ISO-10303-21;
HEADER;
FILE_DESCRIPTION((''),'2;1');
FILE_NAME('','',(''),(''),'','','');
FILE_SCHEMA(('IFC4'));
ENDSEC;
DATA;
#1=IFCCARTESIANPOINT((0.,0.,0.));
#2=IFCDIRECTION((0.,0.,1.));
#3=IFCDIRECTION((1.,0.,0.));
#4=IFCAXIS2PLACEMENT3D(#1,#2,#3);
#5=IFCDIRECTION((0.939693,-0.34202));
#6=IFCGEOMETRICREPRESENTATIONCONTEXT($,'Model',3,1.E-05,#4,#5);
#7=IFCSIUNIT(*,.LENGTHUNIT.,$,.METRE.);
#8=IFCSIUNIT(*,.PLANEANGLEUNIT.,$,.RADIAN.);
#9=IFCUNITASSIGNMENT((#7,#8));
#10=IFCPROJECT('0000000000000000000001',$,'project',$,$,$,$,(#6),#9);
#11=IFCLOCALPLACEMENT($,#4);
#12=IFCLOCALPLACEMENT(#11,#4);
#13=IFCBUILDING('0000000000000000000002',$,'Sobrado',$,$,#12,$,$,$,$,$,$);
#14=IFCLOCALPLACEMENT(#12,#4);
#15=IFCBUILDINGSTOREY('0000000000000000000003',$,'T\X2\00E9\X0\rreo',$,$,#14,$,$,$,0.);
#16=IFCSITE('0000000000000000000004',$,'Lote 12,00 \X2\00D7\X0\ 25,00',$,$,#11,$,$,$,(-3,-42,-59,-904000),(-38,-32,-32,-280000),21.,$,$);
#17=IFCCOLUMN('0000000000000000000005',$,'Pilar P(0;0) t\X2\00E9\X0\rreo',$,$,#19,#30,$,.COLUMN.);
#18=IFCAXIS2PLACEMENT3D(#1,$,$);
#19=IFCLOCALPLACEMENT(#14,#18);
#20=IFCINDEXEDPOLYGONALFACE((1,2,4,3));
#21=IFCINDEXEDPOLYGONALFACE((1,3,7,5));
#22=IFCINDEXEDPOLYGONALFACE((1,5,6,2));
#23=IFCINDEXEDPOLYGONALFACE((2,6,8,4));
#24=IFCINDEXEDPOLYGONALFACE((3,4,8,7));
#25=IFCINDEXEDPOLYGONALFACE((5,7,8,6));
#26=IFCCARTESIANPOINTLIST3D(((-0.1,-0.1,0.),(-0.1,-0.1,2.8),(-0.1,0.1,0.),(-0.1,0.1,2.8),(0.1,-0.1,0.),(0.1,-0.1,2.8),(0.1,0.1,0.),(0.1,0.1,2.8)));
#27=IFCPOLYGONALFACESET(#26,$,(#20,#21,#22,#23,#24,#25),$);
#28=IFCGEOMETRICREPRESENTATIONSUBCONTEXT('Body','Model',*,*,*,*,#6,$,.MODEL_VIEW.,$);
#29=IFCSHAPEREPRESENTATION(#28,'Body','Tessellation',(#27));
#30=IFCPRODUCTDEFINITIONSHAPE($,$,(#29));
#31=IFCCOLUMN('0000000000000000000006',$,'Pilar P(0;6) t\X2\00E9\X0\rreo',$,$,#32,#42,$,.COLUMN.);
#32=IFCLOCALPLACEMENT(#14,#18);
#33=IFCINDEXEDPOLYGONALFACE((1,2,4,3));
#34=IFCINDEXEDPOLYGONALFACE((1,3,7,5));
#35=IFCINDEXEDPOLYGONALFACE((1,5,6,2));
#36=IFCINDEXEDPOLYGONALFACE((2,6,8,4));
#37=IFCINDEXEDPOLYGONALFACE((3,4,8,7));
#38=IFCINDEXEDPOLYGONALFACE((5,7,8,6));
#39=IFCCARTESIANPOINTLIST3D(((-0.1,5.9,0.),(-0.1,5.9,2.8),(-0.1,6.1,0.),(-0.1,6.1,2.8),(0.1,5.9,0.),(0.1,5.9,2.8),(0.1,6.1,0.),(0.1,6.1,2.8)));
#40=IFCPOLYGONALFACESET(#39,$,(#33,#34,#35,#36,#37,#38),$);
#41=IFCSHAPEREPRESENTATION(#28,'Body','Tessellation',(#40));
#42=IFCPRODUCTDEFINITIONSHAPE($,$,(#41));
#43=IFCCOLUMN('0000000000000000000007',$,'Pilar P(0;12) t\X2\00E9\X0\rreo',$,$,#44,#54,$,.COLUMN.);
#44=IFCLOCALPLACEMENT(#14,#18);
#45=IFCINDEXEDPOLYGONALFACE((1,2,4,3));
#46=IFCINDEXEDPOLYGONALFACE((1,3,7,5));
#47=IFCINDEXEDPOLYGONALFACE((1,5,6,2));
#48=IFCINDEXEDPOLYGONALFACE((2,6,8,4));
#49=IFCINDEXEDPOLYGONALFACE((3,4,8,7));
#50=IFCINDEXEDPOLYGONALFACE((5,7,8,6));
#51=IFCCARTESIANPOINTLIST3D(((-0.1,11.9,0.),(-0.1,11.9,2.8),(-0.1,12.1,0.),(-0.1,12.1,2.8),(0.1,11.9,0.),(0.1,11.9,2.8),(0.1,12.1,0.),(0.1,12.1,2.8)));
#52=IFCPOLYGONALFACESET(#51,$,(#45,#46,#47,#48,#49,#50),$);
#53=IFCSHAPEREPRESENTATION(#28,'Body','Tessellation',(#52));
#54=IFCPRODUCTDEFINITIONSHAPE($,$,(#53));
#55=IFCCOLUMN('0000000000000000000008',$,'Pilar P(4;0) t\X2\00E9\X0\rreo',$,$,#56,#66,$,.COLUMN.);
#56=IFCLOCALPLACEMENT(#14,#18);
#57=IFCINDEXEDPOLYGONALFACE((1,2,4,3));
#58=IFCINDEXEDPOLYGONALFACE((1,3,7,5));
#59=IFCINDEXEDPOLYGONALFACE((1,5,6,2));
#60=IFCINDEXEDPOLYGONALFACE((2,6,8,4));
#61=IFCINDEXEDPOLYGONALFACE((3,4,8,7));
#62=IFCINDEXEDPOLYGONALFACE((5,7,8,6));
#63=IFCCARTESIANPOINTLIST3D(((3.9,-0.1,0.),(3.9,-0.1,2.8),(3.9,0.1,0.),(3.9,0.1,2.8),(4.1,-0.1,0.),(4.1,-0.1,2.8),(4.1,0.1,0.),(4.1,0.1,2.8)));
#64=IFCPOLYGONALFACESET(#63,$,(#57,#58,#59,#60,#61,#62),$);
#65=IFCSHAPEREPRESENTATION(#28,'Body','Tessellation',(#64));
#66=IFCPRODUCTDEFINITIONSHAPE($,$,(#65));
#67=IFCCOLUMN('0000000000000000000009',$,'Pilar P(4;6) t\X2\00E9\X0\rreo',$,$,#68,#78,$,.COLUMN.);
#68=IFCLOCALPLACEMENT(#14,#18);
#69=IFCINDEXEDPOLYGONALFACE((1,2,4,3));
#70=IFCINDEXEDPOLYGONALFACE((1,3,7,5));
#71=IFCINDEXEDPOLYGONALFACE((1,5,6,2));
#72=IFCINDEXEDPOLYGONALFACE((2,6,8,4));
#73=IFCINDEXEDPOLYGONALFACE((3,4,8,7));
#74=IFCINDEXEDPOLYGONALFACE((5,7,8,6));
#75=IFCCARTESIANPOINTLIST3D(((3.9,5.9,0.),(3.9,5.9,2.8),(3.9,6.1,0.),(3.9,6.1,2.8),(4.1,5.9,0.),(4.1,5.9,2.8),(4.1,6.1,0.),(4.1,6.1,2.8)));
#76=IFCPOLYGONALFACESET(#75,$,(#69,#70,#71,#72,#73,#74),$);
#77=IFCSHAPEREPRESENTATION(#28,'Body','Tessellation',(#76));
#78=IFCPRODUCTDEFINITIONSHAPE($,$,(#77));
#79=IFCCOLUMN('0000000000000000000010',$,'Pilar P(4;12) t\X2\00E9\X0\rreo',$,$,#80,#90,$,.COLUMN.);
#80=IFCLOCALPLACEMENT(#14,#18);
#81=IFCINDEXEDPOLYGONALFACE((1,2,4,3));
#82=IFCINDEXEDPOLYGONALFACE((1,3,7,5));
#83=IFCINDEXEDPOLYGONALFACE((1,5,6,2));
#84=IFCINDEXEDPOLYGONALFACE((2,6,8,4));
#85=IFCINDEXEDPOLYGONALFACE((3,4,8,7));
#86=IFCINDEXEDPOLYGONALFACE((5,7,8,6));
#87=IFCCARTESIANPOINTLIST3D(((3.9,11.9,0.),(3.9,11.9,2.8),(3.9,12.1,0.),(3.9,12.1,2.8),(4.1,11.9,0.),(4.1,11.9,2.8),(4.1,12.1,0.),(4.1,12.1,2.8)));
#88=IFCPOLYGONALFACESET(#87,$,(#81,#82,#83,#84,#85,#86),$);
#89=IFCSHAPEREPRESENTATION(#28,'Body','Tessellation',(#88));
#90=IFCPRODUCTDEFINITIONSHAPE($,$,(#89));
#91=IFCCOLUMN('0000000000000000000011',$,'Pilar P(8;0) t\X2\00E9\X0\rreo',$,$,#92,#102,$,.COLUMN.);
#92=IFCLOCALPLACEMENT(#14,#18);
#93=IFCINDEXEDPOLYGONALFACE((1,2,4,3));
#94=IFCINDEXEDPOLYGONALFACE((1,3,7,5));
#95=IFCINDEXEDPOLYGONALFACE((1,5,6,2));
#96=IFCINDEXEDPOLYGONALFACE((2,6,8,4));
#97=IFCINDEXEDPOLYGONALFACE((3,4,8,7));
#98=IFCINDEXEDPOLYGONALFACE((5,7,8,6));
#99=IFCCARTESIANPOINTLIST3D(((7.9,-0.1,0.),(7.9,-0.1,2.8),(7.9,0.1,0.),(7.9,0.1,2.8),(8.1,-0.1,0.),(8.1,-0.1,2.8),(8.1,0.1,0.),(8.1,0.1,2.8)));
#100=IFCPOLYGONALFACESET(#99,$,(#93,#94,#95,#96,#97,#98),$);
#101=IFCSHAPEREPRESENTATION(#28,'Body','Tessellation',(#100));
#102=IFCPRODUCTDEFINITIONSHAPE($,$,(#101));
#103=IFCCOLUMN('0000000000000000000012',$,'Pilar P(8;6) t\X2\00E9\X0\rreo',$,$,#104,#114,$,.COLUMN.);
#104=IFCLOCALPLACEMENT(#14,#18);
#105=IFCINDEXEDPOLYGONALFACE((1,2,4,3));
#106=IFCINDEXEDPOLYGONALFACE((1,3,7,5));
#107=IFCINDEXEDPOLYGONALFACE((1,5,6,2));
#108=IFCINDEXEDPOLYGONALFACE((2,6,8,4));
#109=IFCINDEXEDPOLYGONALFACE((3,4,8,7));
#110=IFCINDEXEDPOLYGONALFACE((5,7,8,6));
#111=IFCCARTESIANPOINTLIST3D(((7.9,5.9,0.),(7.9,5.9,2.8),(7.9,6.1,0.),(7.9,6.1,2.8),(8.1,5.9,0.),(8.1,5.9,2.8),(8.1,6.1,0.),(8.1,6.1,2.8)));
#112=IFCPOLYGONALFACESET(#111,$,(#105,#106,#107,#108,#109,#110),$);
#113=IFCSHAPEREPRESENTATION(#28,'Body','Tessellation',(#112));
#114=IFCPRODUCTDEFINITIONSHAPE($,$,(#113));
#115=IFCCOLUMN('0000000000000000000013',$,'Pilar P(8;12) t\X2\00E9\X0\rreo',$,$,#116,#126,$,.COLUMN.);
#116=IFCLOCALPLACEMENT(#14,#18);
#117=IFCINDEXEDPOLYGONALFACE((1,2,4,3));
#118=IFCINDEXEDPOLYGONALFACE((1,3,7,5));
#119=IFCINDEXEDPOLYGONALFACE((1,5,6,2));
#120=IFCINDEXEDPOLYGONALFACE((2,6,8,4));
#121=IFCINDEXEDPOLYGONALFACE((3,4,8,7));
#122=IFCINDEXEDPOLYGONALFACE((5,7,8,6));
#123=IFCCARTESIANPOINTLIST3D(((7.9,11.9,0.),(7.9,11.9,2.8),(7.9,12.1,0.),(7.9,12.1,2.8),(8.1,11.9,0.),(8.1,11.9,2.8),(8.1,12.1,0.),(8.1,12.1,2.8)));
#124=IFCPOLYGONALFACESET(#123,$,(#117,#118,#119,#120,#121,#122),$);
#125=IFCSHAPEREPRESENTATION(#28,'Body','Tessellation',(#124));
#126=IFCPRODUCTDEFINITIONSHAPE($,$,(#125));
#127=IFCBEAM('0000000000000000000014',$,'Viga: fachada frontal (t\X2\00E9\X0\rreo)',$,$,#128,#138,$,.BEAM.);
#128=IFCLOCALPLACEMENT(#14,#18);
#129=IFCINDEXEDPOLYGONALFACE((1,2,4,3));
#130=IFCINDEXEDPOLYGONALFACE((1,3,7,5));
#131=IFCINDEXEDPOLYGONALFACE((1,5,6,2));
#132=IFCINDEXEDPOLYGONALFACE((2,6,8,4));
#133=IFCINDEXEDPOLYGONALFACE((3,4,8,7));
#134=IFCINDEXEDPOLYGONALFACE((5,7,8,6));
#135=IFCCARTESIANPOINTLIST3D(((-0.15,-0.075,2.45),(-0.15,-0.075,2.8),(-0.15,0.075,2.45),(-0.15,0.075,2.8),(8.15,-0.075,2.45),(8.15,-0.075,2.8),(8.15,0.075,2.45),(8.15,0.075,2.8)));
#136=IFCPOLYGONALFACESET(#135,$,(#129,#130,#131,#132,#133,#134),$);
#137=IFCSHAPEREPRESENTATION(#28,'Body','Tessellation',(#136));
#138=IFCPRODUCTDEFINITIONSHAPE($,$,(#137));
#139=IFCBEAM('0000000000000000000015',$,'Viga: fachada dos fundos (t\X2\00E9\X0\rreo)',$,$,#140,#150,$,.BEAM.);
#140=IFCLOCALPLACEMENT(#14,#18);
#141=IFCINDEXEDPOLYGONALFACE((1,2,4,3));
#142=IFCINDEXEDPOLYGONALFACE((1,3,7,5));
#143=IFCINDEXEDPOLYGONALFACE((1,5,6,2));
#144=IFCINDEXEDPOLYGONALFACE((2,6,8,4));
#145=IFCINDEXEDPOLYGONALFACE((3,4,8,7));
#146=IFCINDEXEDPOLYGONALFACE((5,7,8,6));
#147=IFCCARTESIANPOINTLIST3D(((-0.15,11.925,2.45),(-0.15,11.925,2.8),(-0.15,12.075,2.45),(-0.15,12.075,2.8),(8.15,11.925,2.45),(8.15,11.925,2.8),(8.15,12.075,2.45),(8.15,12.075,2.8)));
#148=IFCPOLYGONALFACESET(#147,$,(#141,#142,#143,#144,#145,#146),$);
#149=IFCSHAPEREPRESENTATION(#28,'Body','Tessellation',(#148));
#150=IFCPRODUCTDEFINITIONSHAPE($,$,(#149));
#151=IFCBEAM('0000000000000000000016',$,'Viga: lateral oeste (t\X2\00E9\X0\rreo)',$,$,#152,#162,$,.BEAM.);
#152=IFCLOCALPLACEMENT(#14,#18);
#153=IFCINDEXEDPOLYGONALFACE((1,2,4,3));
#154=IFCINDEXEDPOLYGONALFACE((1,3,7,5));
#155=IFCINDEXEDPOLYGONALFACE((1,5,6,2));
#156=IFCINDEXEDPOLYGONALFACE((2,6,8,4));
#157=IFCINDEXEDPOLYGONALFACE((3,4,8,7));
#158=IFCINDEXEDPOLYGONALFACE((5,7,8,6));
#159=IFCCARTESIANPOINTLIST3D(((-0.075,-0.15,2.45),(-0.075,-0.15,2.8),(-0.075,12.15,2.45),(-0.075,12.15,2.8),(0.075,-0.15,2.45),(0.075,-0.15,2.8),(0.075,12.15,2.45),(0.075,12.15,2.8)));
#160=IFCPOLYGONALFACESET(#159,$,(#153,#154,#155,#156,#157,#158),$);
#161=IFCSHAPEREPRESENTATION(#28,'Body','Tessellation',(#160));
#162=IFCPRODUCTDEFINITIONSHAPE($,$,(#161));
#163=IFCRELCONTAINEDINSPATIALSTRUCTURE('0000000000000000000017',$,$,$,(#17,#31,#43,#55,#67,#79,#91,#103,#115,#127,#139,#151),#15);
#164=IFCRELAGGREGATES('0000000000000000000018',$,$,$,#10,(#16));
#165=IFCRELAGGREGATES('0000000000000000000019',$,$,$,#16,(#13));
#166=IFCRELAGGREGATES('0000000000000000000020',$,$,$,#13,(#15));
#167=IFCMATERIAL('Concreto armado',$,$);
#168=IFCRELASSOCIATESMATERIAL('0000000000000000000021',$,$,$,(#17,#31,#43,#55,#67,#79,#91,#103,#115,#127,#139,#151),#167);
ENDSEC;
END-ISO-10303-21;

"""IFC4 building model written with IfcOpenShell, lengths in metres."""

from ifc_helpers import new_model, si_unit, direction, frame, origin_with_axes, place, context, subcontext, project, spatial, line, indexed_curve, outline, extrude, material, element, save


model = new_model("IFC4")

# Units and contexts
model_context = context("Model", 3, precision=1e-05, world=origin_with_axes(), true_north=direction((0.939693, -0.34202)))
body_context = subcontext(model_context, "Body", "Model", "MODEL_VIEW")
ifc_project = project(units=[si_unit("LENGTHUNIT", "METRE"), si_unit("PLANEANGLEUNIT", "RADIAN")], contexts=[model_context])

# Site, building, storey
site_placement = place(None, origin_with_axes())
site = spatial("IfcSite", under=ifc_project, at=site_placement, Name="Lote 12,00 × 25,00", RefLatitude=(-3, -42, -59, -904000), RefLongitude=(-38, -32, -32, -280000), RefElevation=21.0)
building_placement = place(site_placement, origin_with_axes())
building = spatial("IfcBuilding", under=site, at=building_placement, Name="Sobrado")
storey_placement = place(building_placement, origin_with_axes())
storey = spatial("IfcBuildingStorey", under=building, at=storey_placement, Name="Térreo", Elevation=0.0)

# Columns
ifc_material_1 = material(Name="Concreto armado")
column_1_placement = place(storey_placement, origin_with_axes())
element("IfcColumn", 1, at=column_1_placement, inside=storey, material=ifc_material_1, Name="Pilar P(0;0) térreo", PredefinedType="COLUMN", context=body_context, shape_type="SweptSolid", body=[
    extrude(outline(indexed_curve([(-0.1, -0.1), (0.1, -0.1), (0.1, 0.1), (-0.1, 0.1)], segments=[line(1, 2, 3, 4, 1)])), origin_with_axes(), (0.0, 0.0, 1.0), 2.8),
])
column_2_placement = place(storey_placement, origin_with_axes())
element("IfcColumn", 2, at=column_2_placement, inside=storey, material=ifc_material_1, Name="Pilar P(0;6) térreo", PredefinedType="COLUMN", context=body_context, shape_type="SweptSolid", body=[
    extrude(outline(indexed_curve([(-0.1, 5.9), (0.1, 5.9), (0.1, 6.1), (-0.1, 6.1)], segments=[line(1, 2, 3, 4, 1)])), origin_with_axes(), (0.0, 0.0, 1.0), 2.8),
])
column_3_placement = place(storey_placement, origin_with_axes())
element("IfcColumn", 3, at=column_3_placement, inside=storey, material=ifc_material_1, Name="Pilar P(0;12) térreo", PredefinedType="COLUMN", context=body_context, shape_type="SweptSolid", body=[
    extrude(outline(indexed_curve([(-0.1, 11.9), (0.1, 11.9), (0.1, 12.1), (-0.1, 12.1)], segments=[line(1, 2, 3, 4, 1)])), origin_with_axes(), (0.0, 0.0, 1.0), 2.8),
])
column_4_placement = place(storey_placement, origin_with_axes())
element("IfcColumn", 4, at=column_4_placement, inside=storey, material=ifc_material_1, Name="Pilar P(4;0) térreo", PredefinedType="COLUMN", context=body_context, shape_type="SweptSolid", body=[
    extrude(outline(indexed_curve([(3.9, -0.1), (4.1, -0.1), (4.1, 0.1), (3.9, 0.1)], segments=[line(1, 2, 3, 4, 1)])), origin_with_axes(), (0.0, 0.0, 1.0), 2.8),
])
column_5_placement = place(storey_placement, origin_with_axes())
element("IfcColumn", 5, at=column_5_placement, inside=storey, material=ifc_material_1, Name="Pilar P(4;6) térreo", PredefinedType="COLUMN", context=body_context, shape_type="SweptSolid", body=[
    extrude(outline(indexed_curve([(3.9, 5.9), (4.1, 5.9), (4.1, 6.1), (3.9, 6.1)], segments=[line(1, 2, 3, 4, 1)])), origin_with_axes(), (0.0, 0.0, 1.0), 2.8),
])
column_6_placement = place(storey_placement, origin_with_axes())
element("IfcColumn", 6, at=column_6_placement, inside=storey, material=ifc_material_1, Name="Pilar P(4;12) térreo", PredefinedType="COLUMN", context=body_context, shape_type="SweptSolid", body=[
    extrude(outline(indexed_curve([(3.9, 11.9), (4.1, 11.9), (4.1, 12.1), (3.9, 12.1)], segments=[line(1, 2, 3, 4, 1)])), origin_with_axes(), (0.0, 0.0, 1.0), 2.8),
])
column_7_placement = place(storey_placement, origin_with_axes())
element("IfcColumn", 7, at=column_7_placement, inside=storey, material=ifc_material_1, Name="Pilar P(8;0) térreo", PredefinedType="COLUMN", context=body_context, shape_type="SweptSolid", body=[
    extrude(outline(indexed_curve([(7.9, -0.1), (8.1, -0.1), (8.1, 0.1), (7.9, 0.1)], segments=[line(1, 2, 3, 4, 1)])), origin_with_axes(), (0.0, 0.0, 1.0), 2.8),
])
column_8_placement = place(storey_placement, origin_with_axes())
element("IfcColumn", 8, at=column_8_placement, inside=storey, material=ifc_material_1, Name="Pilar P(8;6) térreo", PredefinedType="COLUMN", context=body_context, shape_type="SweptSolid", body=[
    extrude(outline(indexed_curve([(7.9, 5.9), (8.1, 5.9), (8.1, 6.1), (7.9, 6.1)], segments=[line(1, 2, 3, 4, 1)])), origin_with_axes(), (0.0, 0.0, 1.0), 2.8),
])
column_9_placement = place(storey_placement, origin_with_axes())
element("IfcColumn", 9, at=column_9_placement, inside=storey, material=ifc_material_1, Name="Pilar P(8;12) térreo", PredefinedType="COLUMN", context=body_context, shape_type="SweptSolid", body=[
    extrude(outline(indexed_curve([(7.9, 11.9), (8.1, 11.9), (8.1, 12.1), (7.9, 12.1)], segments=[line(1, 2, 3, 4, 1)])), origin_with_axes(), (0.0, 0.0, 1.0), 2.8),
])

# Beams
beam_1_placement = place(storey_placement, origin_with_axes())
element("IfcBeam", 10, at=beam_1_placement, inside=storey, material=ifc_material_1, Name="Viga: fachada frontal (térreo)", PredefinedType="BEAM", context=body_context, shape_type="SweptSolid", body=[
    extrude(outline(indexed_curve([(-0.15, -0.075), (8.15, -0.075), (8.15, 0.075), (-0.15, 0.075)], segments=[line(1, 2, 3, 4, 1)])), frame((0.0, 0.0, 2.45), z_axis=(0.0, 0.0, 1.0), x_axis=(1.0, 0.0, 0.0)), (0.0, 0.0, 1.0), 0.35),
])
beam_2_placement = place(storey_placement, origin_with_axes())
element("IfcBeam", 11, at=beam_2_placement, inside=storey, material=ifc_material_1, Name="Viga: fachada dos fundos (térreo)", PredefinedType="BEAM", context=body_context, shape_type="SweptSolid", body=[
    extrude(outline(indexed_curve([(-0.15, 11.925), (8.15, 11.925), (8.15, 12.075), (-0.15, 12.075)], segments=[line(1, 2, 3, 4, 1)])), frame((0.0, 0.0, 2.45), z_axis=(0.0, 0.0, 1.0), x_axis=(1.0, 0.0, 0.0)), (0.0, 0.0, 1.0), 0.35),
])
beam_3_placement = place(storey_placement, origin_with_axes())
element("IfcBeam", 12, at=beam_3_placement, inside=storey, material=ifc_material_1, Name="Viga: lateral oeste (térreo)", PredefinedType="BEAM", context=body_context, shape_type="SweptSolid", body=[
    extrude(outline(indexed_curve([(-0.075, -0.15), (0.075, -0.15), (0.075, 12.15), (-0.075, 12.15)], segments=[line(1, 2, 3, 4, 1)])), frame((0.0, 0.0, 2.45), z_axis=(0.0, 0.0, 1.0), x_axis=(1.0, 0.0, 0.0)), (0.0, 0.0, 1.0), 0.35),
])

save(model, "model.ifc")
